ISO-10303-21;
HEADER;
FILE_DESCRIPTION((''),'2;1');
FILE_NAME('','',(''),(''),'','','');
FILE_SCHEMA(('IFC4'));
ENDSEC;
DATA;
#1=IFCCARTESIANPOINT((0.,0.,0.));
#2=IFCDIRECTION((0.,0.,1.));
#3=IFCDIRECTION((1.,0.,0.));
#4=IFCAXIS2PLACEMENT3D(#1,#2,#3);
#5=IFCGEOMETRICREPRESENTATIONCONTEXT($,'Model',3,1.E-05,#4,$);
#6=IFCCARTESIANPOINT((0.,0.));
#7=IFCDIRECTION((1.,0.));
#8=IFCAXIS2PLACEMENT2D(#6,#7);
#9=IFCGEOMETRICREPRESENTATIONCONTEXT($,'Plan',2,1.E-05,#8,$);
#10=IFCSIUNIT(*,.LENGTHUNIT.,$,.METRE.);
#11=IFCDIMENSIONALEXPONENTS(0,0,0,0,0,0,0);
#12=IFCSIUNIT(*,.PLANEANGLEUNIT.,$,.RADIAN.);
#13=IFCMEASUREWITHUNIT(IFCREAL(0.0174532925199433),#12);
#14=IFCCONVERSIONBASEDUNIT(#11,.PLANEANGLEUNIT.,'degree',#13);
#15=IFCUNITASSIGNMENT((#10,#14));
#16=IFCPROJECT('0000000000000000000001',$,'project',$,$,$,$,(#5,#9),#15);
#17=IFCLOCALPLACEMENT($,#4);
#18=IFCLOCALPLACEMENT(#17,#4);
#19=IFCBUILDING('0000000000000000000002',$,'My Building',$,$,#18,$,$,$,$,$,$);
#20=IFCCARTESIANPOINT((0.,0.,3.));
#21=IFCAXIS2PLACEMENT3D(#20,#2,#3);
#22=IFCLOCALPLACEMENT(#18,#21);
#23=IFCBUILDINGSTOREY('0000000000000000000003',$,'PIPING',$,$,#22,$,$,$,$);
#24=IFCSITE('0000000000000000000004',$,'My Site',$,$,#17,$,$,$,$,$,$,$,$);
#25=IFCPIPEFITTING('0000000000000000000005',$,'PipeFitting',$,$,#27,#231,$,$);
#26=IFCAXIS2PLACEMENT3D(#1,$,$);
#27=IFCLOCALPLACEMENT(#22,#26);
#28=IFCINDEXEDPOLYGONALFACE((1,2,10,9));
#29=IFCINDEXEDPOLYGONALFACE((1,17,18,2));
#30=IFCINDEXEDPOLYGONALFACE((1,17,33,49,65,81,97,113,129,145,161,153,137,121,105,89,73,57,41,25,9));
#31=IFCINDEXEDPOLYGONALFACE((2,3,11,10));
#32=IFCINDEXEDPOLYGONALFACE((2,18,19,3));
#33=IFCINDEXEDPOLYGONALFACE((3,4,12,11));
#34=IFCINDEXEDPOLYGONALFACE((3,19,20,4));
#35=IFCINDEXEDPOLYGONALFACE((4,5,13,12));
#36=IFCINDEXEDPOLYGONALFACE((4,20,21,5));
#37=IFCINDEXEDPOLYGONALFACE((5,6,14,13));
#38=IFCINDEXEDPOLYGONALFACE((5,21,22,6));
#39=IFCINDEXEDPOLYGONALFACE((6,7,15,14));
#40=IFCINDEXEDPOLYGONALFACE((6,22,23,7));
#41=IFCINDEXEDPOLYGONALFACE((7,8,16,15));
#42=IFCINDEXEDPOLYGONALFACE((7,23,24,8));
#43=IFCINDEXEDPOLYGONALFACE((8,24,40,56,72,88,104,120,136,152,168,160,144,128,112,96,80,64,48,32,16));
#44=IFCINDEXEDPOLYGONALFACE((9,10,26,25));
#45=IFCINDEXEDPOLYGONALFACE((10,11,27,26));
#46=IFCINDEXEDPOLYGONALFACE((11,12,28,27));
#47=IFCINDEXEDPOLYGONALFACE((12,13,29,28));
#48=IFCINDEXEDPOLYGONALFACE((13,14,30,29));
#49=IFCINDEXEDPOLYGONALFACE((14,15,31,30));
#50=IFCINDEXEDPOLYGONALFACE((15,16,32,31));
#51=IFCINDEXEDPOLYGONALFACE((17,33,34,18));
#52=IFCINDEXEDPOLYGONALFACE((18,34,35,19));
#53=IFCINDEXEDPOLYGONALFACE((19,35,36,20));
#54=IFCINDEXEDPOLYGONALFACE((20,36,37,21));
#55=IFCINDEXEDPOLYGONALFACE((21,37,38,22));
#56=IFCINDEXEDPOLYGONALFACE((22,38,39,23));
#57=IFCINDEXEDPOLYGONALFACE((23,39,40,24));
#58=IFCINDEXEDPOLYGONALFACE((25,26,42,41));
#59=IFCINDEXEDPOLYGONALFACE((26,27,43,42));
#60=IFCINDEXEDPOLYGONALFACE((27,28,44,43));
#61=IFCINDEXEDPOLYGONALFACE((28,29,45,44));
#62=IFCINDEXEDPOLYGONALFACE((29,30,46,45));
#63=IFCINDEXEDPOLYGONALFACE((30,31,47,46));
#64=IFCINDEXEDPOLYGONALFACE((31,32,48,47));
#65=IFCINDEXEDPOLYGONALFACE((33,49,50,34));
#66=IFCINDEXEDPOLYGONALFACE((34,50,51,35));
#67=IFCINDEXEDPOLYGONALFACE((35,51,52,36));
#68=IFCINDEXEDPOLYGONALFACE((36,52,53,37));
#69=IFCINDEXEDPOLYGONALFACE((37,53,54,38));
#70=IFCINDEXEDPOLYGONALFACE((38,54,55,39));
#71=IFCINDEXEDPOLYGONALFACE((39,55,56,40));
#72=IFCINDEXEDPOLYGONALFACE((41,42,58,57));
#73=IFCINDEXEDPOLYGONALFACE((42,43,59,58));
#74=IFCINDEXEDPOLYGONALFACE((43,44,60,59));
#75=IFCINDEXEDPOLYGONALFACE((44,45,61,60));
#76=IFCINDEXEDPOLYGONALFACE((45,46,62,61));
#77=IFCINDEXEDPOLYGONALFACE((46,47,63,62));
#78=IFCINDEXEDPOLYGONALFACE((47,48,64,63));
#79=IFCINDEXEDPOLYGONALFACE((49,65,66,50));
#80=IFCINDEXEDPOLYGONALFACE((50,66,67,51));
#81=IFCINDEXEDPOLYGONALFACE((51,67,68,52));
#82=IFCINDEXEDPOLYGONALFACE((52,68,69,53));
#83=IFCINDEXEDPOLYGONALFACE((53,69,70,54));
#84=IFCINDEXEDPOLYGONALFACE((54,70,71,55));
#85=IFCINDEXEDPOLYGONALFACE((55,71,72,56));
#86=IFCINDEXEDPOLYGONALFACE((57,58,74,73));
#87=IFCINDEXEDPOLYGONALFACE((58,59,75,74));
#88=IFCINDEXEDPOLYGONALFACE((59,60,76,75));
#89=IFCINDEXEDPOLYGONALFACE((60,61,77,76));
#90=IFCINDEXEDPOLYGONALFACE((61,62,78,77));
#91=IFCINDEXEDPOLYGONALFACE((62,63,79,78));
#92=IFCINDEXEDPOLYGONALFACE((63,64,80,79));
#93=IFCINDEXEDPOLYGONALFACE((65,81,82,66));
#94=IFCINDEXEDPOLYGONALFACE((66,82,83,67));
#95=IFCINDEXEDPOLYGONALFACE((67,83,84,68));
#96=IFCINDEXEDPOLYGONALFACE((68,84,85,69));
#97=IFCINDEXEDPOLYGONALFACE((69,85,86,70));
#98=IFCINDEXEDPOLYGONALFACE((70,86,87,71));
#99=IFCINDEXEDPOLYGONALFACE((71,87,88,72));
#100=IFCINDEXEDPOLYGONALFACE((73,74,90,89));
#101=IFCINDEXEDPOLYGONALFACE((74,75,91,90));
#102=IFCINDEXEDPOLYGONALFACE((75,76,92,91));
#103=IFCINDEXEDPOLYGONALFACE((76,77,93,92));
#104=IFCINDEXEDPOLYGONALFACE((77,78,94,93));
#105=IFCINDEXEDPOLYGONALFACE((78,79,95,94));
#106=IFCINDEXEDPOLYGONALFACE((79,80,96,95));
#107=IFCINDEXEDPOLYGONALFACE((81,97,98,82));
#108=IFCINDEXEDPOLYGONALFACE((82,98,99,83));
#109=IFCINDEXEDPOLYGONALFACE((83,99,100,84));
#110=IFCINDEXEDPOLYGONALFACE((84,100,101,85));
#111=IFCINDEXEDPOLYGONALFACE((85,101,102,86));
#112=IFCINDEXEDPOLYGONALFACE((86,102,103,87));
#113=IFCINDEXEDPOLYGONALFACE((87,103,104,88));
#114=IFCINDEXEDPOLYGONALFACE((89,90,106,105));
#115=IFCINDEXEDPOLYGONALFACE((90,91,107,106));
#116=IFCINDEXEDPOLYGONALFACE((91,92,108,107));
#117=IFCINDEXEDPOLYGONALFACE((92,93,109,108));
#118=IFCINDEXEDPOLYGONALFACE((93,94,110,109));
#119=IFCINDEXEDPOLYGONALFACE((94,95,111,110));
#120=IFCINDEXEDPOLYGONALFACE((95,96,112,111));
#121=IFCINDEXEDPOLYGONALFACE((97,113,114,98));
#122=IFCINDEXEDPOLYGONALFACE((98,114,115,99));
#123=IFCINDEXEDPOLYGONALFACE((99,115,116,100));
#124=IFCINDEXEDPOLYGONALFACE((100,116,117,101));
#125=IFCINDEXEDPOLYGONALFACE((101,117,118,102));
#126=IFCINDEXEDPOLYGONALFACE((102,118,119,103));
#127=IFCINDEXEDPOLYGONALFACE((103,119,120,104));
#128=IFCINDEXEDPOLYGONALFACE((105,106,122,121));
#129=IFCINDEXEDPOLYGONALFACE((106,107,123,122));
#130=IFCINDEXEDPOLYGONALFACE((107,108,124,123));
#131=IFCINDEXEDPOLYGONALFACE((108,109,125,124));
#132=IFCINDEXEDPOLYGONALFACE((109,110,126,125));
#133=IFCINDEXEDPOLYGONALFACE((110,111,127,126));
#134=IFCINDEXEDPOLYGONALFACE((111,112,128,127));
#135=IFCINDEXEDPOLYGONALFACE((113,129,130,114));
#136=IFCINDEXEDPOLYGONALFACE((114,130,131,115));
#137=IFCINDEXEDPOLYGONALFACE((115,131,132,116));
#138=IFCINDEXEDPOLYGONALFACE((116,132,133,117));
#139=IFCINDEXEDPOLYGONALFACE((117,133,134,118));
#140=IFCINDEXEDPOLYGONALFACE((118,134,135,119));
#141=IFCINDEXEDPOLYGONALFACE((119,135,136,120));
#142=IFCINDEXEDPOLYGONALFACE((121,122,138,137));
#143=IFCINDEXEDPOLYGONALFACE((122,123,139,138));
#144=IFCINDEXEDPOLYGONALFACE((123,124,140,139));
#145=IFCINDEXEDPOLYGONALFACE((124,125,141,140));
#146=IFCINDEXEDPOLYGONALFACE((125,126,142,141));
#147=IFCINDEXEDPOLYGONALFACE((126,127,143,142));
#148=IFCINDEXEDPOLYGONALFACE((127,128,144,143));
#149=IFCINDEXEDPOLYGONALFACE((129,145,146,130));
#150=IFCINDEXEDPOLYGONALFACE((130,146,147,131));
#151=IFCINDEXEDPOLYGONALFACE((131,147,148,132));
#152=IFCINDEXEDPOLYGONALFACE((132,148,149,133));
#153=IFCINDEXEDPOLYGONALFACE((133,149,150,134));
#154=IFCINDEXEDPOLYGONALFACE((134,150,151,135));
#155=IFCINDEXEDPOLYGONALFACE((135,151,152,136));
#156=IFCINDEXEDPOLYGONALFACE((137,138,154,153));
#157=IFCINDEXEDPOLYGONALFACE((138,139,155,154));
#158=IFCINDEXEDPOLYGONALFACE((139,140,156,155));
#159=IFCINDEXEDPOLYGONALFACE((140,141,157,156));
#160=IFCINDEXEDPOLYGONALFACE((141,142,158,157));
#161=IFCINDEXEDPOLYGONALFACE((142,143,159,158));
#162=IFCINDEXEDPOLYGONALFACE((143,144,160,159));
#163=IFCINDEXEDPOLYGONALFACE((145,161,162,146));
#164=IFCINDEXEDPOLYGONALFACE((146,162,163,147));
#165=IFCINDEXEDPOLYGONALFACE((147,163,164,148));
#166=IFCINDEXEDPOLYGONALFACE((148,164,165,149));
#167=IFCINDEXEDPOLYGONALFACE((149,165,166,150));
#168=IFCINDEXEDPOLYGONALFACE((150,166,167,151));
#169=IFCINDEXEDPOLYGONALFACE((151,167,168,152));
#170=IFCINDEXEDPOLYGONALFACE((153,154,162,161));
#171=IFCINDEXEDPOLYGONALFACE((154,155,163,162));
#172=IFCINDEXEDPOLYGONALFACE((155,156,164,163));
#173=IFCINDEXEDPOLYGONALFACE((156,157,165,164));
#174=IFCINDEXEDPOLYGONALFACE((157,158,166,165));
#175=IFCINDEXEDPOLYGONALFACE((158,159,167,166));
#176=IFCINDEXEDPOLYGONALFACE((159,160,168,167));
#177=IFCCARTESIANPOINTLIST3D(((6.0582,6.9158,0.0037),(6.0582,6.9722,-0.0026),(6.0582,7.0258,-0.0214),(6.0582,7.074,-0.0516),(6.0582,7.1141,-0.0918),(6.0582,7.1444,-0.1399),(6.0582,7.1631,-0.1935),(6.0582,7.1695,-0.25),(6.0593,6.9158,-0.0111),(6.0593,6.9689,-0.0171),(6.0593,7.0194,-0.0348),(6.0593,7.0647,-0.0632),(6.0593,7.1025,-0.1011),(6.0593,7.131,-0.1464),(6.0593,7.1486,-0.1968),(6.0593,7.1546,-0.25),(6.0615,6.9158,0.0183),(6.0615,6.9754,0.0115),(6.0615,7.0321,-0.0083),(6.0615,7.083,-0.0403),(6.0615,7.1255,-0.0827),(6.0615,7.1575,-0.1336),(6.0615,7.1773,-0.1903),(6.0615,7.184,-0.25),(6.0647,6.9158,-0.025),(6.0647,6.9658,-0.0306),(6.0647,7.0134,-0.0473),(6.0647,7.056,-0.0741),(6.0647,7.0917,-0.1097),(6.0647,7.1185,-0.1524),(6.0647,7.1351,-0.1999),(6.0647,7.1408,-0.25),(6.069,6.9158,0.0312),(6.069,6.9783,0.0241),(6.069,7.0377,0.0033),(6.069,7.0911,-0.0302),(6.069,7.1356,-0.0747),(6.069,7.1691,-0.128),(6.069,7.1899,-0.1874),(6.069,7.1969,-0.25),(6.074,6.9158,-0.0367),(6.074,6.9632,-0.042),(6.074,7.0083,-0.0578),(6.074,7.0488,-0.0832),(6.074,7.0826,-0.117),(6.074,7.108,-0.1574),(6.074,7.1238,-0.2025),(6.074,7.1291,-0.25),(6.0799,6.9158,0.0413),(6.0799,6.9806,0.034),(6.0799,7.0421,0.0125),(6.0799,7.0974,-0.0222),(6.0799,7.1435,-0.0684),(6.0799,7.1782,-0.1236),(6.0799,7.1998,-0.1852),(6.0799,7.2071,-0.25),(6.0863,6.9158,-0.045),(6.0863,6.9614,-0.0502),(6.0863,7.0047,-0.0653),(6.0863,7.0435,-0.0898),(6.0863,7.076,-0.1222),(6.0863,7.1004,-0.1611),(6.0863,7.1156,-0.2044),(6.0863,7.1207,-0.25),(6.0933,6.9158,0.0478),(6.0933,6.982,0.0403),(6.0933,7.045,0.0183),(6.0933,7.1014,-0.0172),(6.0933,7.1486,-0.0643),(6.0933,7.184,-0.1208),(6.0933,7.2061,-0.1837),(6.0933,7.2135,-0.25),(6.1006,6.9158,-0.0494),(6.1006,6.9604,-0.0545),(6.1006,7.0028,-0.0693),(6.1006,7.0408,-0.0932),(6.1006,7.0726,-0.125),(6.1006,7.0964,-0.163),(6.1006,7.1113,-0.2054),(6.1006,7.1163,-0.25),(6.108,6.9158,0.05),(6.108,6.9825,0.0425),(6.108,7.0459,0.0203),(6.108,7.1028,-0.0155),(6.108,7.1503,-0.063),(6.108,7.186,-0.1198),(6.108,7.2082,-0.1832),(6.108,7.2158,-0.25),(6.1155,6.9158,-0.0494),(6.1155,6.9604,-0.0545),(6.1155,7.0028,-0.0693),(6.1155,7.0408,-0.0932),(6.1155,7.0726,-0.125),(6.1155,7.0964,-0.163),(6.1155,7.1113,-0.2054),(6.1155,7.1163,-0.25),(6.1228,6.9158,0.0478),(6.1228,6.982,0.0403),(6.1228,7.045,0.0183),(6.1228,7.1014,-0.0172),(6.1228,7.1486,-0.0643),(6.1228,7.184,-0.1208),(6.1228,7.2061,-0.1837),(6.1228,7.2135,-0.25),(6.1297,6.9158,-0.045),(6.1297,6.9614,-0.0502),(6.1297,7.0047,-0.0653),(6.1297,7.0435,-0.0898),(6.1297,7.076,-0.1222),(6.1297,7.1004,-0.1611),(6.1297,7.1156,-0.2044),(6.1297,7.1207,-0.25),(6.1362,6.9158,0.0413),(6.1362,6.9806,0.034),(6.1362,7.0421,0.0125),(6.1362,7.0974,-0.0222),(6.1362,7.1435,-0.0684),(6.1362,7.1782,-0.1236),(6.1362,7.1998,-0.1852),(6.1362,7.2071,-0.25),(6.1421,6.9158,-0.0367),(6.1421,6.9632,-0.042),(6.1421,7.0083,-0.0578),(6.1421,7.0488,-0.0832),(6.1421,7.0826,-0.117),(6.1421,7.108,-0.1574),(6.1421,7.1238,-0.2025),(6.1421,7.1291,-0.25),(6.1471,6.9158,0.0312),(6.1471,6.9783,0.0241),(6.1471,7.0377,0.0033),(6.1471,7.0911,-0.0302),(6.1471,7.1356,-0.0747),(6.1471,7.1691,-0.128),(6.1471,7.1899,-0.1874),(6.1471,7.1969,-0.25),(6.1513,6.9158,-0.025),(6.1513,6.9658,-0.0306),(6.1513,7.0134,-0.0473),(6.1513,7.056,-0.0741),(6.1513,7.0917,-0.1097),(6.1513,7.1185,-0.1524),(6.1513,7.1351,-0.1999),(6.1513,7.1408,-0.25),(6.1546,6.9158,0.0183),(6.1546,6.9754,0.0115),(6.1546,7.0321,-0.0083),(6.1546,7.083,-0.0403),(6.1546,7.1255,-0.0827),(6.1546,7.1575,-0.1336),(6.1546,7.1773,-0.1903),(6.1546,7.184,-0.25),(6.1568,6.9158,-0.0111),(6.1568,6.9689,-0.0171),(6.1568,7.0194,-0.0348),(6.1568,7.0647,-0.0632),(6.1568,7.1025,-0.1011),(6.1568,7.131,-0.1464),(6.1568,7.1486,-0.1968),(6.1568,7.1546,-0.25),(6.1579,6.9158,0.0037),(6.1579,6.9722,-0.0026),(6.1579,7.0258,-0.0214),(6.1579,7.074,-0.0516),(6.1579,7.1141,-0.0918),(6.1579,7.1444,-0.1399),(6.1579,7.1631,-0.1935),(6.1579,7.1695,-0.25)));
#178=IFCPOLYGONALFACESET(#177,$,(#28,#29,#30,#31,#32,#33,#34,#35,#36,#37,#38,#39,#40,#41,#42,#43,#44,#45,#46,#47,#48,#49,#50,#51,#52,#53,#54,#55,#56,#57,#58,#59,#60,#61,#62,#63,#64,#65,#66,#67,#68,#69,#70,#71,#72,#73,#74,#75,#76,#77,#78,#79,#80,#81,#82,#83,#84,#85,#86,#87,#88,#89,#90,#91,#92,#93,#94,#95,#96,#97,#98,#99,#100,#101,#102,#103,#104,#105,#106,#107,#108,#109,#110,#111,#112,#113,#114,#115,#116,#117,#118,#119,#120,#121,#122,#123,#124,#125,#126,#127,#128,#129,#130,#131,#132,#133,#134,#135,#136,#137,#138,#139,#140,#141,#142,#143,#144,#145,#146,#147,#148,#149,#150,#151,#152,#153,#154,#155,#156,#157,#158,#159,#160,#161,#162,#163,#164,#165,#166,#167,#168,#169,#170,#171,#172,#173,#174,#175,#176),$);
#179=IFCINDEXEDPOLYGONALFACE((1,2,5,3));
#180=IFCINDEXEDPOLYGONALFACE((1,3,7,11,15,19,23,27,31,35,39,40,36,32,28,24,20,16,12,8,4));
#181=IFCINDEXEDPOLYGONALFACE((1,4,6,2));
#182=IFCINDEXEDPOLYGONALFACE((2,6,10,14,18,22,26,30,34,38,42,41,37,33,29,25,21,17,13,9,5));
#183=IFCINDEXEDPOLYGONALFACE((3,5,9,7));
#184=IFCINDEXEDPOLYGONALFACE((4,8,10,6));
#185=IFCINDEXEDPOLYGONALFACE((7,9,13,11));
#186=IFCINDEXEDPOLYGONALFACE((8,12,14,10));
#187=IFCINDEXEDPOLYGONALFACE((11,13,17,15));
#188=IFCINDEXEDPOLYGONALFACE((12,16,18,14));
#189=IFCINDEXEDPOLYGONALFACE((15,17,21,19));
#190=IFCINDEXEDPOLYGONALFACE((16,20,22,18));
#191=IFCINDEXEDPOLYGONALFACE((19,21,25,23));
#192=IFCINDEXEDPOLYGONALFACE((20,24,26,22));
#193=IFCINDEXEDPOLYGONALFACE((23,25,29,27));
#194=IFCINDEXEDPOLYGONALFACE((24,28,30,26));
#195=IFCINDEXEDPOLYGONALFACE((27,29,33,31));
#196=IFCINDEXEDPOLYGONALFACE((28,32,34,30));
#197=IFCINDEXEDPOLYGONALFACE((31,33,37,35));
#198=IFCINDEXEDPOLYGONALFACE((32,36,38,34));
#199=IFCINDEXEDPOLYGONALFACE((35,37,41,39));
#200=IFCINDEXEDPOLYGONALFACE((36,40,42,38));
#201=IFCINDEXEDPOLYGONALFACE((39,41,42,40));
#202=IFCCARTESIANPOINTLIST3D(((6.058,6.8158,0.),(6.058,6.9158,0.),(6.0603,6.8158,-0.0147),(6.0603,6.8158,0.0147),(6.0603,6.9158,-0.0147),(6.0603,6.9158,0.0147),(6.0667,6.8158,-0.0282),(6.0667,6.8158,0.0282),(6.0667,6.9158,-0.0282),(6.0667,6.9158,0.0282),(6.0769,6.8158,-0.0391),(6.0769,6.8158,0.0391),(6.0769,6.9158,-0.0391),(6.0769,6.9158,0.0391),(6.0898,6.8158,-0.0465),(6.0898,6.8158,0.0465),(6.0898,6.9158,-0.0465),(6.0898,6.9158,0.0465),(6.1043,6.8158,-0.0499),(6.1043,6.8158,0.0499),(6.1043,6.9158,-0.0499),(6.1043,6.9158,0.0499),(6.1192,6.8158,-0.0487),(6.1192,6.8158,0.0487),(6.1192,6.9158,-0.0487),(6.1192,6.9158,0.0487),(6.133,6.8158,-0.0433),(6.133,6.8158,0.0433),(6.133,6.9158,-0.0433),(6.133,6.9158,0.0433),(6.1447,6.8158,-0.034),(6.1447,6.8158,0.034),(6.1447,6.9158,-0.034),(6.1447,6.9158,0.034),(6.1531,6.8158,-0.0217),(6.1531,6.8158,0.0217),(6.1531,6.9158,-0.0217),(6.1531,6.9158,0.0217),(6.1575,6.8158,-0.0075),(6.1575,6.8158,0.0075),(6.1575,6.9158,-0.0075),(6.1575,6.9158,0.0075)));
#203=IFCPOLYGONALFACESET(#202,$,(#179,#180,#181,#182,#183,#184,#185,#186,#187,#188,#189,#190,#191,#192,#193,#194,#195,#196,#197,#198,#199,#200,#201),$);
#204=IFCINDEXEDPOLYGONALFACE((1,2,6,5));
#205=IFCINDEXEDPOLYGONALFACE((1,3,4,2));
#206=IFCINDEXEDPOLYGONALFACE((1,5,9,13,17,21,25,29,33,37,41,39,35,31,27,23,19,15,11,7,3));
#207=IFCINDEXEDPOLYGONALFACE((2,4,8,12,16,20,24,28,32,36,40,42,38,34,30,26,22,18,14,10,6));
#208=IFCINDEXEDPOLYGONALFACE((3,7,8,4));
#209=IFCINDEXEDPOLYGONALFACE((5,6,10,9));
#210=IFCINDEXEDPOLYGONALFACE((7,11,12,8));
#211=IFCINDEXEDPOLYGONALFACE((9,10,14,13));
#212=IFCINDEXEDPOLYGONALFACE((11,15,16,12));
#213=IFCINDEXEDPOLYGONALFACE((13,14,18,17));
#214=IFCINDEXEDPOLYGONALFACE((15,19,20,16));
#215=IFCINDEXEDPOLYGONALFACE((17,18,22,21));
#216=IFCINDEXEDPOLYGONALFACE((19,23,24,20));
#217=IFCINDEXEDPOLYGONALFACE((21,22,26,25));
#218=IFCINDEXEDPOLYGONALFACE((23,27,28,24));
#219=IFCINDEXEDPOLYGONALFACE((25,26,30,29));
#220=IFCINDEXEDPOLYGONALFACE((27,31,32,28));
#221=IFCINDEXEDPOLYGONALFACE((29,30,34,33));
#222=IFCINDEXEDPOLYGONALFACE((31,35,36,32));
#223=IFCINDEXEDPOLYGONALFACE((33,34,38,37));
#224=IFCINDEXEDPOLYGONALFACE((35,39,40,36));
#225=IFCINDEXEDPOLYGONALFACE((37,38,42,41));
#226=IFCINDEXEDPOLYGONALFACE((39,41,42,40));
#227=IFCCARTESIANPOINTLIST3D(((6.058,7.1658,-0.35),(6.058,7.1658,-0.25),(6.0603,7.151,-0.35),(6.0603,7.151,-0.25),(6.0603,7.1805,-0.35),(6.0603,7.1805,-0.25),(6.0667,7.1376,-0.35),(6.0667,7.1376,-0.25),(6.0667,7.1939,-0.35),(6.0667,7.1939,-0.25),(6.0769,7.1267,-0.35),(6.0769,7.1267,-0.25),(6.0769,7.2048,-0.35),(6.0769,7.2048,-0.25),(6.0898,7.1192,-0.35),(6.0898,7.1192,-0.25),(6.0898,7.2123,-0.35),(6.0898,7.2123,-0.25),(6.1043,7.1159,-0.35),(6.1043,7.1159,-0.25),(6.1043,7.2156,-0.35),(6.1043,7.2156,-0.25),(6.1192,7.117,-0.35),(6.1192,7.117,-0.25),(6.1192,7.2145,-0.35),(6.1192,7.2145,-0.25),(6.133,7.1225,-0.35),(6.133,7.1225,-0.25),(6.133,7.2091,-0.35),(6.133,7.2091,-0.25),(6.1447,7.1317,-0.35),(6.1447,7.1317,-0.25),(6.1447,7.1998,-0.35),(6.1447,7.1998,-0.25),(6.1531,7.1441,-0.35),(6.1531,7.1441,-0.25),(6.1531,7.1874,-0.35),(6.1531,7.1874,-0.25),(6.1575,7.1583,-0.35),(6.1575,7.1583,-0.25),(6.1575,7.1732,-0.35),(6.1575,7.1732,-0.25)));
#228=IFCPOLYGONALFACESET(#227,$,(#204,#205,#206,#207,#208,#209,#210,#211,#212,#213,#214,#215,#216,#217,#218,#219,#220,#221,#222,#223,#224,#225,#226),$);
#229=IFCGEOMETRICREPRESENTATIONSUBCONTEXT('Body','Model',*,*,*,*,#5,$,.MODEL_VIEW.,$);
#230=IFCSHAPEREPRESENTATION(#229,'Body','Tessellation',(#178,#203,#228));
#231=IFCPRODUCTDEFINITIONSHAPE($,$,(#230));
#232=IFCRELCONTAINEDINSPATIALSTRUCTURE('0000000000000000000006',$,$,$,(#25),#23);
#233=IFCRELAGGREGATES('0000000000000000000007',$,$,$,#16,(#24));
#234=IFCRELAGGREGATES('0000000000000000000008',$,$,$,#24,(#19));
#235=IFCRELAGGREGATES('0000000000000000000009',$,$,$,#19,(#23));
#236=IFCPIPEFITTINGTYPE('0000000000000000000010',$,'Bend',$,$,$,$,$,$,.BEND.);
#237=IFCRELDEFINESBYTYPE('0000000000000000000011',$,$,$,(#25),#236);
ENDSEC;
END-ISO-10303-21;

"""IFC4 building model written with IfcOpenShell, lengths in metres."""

from ifc_helpers import new_model, entity, si_unit, converted_unit, frame, origin_with_axes, origin_2d_with_axis, place, context, subcontext, project, spatial, line, indexed_curve, circle, outline, extrude, source, transform, mapped, type_object, type_shapes, element, save


model = new_model("IFC4")

# Units and contexts
model_context = context("Model", 3, precision=1e-05, world=origin_with_axes())
plan_context = context("Plan", 2, precision=1e-05, world=origin_2d_with_axis())
body_context = subcontext(model_context, "Body", "Model", "MODEL_VIEW")
ifc_project = project(units=[si_unit("LENGTHUNIT", "METRE"), converted_unit("PLANEANGLEUNIT", "degree", entity("IfcReal", 0.0174532925199433), si_unit("PLANEANGLEUNIT", "RADIAN"), dimensions=[0, 0, 0, 0, 0, 0, 0])], contexts=[model_context, plan_context])

# Site, building, storey
site_placement = place(None, origin_with_axes())
site = spatial("IfcSite", under=ifc_project, at=site_placement, Name="My Site")
building_placement = place(site_placement, origin_with_axes())
building = spatial("IfcBuilding", under=site, at=building_placement, Name="My Building")
storey_placement = place(building_placement, frame((0.0, 0.0, 3.0), z_axis=(0.0, 0.0, 1.0), x_axis=(1.0, 0.0, 0.0)))
storey = spatial("IfcBuildingStorey", under=building, at=storey_placement, Name="PIPING")

# Pipe fitting, opening
pipe_fitting_type = type_object("IfcPipeFittingType", Name="Bend", PredefinedType="BEND")
shared_shape = source(origin_with_axes(), body_context, "Body", "SolidModel", [
    entity("IfcSweptDiskSolid", entity("IfcIndexedPolyCurve", entity("IfcCartesianPointList3D", [[0.0, 0.0, 0.1], [0.0, -0.0732, 0.2768], [0.0, -0.25, 0.35]]), [entity("IfcArcIndex", [1, 2, 3])]), 0.05),
    extrude(circle(Radius=0.05), origin_with_axes(), (0.0, 0.0, 1.0), 0.1),
    extrude(circle(Radius=0.05), frame((0.0, -0.25, 0.35), z_axis=(0.0, -1.0, 0.0), x_axis=(1.0, 0.0, 0.0)), (0.0, 0.0, 1.0), 0.1),
])
type_shapes(pipe_fitting_type, [shared_shape])
pipe_fitting_1_placement = place(storey_placement, frame((6.108, 6.8158, 0.0), z_axis=(0.0, 1.0, 0.0), x_axis=(-1.0, 0.0, 0.0)))
pipe_fitting_1 = element("IfcPipeFitting", 1, at=pipe_fitting_1_placement, inside=storey, type_object=pipe_fitting_type, Name="PipeFitting", context=body_context, shape_type="MappedRepresentation", body=[
    mapped(shared_shape, transform((0.0, 0.0, 0.0), x_axis=(1.0, 0.0, 0.0), y_axis=(0.0, 1.0, 0.0), z_axis=(0.0, 0.0, 1.0), scale=1.0)),
])
opening_1_placement = place(pipe_fitting_1_placement, frame((6.108, -3.0, -6.8158), z_axis=(0.0, 1.0, 0.0), x_axis=(-1.0, 0.0, 0.0)))
element("IfcOpeningElement", 2, at=opening_1_placement, cuts=pipe_fitting_1, PredefinedType="OPENING", context=body_context, shape_type="SweptSolid", body=[
    extrude(outline(indexed_curve([(0.0, 0.0), (0.5, 0.0), (0.5, 0.5), (0.0, 0.5)], segments=[line(1, 2, 3, 4, 1)])), origin_with_axes(), (0.0, 0.0, 1.0), 0.5),
])

save(model, "model.ifc")
